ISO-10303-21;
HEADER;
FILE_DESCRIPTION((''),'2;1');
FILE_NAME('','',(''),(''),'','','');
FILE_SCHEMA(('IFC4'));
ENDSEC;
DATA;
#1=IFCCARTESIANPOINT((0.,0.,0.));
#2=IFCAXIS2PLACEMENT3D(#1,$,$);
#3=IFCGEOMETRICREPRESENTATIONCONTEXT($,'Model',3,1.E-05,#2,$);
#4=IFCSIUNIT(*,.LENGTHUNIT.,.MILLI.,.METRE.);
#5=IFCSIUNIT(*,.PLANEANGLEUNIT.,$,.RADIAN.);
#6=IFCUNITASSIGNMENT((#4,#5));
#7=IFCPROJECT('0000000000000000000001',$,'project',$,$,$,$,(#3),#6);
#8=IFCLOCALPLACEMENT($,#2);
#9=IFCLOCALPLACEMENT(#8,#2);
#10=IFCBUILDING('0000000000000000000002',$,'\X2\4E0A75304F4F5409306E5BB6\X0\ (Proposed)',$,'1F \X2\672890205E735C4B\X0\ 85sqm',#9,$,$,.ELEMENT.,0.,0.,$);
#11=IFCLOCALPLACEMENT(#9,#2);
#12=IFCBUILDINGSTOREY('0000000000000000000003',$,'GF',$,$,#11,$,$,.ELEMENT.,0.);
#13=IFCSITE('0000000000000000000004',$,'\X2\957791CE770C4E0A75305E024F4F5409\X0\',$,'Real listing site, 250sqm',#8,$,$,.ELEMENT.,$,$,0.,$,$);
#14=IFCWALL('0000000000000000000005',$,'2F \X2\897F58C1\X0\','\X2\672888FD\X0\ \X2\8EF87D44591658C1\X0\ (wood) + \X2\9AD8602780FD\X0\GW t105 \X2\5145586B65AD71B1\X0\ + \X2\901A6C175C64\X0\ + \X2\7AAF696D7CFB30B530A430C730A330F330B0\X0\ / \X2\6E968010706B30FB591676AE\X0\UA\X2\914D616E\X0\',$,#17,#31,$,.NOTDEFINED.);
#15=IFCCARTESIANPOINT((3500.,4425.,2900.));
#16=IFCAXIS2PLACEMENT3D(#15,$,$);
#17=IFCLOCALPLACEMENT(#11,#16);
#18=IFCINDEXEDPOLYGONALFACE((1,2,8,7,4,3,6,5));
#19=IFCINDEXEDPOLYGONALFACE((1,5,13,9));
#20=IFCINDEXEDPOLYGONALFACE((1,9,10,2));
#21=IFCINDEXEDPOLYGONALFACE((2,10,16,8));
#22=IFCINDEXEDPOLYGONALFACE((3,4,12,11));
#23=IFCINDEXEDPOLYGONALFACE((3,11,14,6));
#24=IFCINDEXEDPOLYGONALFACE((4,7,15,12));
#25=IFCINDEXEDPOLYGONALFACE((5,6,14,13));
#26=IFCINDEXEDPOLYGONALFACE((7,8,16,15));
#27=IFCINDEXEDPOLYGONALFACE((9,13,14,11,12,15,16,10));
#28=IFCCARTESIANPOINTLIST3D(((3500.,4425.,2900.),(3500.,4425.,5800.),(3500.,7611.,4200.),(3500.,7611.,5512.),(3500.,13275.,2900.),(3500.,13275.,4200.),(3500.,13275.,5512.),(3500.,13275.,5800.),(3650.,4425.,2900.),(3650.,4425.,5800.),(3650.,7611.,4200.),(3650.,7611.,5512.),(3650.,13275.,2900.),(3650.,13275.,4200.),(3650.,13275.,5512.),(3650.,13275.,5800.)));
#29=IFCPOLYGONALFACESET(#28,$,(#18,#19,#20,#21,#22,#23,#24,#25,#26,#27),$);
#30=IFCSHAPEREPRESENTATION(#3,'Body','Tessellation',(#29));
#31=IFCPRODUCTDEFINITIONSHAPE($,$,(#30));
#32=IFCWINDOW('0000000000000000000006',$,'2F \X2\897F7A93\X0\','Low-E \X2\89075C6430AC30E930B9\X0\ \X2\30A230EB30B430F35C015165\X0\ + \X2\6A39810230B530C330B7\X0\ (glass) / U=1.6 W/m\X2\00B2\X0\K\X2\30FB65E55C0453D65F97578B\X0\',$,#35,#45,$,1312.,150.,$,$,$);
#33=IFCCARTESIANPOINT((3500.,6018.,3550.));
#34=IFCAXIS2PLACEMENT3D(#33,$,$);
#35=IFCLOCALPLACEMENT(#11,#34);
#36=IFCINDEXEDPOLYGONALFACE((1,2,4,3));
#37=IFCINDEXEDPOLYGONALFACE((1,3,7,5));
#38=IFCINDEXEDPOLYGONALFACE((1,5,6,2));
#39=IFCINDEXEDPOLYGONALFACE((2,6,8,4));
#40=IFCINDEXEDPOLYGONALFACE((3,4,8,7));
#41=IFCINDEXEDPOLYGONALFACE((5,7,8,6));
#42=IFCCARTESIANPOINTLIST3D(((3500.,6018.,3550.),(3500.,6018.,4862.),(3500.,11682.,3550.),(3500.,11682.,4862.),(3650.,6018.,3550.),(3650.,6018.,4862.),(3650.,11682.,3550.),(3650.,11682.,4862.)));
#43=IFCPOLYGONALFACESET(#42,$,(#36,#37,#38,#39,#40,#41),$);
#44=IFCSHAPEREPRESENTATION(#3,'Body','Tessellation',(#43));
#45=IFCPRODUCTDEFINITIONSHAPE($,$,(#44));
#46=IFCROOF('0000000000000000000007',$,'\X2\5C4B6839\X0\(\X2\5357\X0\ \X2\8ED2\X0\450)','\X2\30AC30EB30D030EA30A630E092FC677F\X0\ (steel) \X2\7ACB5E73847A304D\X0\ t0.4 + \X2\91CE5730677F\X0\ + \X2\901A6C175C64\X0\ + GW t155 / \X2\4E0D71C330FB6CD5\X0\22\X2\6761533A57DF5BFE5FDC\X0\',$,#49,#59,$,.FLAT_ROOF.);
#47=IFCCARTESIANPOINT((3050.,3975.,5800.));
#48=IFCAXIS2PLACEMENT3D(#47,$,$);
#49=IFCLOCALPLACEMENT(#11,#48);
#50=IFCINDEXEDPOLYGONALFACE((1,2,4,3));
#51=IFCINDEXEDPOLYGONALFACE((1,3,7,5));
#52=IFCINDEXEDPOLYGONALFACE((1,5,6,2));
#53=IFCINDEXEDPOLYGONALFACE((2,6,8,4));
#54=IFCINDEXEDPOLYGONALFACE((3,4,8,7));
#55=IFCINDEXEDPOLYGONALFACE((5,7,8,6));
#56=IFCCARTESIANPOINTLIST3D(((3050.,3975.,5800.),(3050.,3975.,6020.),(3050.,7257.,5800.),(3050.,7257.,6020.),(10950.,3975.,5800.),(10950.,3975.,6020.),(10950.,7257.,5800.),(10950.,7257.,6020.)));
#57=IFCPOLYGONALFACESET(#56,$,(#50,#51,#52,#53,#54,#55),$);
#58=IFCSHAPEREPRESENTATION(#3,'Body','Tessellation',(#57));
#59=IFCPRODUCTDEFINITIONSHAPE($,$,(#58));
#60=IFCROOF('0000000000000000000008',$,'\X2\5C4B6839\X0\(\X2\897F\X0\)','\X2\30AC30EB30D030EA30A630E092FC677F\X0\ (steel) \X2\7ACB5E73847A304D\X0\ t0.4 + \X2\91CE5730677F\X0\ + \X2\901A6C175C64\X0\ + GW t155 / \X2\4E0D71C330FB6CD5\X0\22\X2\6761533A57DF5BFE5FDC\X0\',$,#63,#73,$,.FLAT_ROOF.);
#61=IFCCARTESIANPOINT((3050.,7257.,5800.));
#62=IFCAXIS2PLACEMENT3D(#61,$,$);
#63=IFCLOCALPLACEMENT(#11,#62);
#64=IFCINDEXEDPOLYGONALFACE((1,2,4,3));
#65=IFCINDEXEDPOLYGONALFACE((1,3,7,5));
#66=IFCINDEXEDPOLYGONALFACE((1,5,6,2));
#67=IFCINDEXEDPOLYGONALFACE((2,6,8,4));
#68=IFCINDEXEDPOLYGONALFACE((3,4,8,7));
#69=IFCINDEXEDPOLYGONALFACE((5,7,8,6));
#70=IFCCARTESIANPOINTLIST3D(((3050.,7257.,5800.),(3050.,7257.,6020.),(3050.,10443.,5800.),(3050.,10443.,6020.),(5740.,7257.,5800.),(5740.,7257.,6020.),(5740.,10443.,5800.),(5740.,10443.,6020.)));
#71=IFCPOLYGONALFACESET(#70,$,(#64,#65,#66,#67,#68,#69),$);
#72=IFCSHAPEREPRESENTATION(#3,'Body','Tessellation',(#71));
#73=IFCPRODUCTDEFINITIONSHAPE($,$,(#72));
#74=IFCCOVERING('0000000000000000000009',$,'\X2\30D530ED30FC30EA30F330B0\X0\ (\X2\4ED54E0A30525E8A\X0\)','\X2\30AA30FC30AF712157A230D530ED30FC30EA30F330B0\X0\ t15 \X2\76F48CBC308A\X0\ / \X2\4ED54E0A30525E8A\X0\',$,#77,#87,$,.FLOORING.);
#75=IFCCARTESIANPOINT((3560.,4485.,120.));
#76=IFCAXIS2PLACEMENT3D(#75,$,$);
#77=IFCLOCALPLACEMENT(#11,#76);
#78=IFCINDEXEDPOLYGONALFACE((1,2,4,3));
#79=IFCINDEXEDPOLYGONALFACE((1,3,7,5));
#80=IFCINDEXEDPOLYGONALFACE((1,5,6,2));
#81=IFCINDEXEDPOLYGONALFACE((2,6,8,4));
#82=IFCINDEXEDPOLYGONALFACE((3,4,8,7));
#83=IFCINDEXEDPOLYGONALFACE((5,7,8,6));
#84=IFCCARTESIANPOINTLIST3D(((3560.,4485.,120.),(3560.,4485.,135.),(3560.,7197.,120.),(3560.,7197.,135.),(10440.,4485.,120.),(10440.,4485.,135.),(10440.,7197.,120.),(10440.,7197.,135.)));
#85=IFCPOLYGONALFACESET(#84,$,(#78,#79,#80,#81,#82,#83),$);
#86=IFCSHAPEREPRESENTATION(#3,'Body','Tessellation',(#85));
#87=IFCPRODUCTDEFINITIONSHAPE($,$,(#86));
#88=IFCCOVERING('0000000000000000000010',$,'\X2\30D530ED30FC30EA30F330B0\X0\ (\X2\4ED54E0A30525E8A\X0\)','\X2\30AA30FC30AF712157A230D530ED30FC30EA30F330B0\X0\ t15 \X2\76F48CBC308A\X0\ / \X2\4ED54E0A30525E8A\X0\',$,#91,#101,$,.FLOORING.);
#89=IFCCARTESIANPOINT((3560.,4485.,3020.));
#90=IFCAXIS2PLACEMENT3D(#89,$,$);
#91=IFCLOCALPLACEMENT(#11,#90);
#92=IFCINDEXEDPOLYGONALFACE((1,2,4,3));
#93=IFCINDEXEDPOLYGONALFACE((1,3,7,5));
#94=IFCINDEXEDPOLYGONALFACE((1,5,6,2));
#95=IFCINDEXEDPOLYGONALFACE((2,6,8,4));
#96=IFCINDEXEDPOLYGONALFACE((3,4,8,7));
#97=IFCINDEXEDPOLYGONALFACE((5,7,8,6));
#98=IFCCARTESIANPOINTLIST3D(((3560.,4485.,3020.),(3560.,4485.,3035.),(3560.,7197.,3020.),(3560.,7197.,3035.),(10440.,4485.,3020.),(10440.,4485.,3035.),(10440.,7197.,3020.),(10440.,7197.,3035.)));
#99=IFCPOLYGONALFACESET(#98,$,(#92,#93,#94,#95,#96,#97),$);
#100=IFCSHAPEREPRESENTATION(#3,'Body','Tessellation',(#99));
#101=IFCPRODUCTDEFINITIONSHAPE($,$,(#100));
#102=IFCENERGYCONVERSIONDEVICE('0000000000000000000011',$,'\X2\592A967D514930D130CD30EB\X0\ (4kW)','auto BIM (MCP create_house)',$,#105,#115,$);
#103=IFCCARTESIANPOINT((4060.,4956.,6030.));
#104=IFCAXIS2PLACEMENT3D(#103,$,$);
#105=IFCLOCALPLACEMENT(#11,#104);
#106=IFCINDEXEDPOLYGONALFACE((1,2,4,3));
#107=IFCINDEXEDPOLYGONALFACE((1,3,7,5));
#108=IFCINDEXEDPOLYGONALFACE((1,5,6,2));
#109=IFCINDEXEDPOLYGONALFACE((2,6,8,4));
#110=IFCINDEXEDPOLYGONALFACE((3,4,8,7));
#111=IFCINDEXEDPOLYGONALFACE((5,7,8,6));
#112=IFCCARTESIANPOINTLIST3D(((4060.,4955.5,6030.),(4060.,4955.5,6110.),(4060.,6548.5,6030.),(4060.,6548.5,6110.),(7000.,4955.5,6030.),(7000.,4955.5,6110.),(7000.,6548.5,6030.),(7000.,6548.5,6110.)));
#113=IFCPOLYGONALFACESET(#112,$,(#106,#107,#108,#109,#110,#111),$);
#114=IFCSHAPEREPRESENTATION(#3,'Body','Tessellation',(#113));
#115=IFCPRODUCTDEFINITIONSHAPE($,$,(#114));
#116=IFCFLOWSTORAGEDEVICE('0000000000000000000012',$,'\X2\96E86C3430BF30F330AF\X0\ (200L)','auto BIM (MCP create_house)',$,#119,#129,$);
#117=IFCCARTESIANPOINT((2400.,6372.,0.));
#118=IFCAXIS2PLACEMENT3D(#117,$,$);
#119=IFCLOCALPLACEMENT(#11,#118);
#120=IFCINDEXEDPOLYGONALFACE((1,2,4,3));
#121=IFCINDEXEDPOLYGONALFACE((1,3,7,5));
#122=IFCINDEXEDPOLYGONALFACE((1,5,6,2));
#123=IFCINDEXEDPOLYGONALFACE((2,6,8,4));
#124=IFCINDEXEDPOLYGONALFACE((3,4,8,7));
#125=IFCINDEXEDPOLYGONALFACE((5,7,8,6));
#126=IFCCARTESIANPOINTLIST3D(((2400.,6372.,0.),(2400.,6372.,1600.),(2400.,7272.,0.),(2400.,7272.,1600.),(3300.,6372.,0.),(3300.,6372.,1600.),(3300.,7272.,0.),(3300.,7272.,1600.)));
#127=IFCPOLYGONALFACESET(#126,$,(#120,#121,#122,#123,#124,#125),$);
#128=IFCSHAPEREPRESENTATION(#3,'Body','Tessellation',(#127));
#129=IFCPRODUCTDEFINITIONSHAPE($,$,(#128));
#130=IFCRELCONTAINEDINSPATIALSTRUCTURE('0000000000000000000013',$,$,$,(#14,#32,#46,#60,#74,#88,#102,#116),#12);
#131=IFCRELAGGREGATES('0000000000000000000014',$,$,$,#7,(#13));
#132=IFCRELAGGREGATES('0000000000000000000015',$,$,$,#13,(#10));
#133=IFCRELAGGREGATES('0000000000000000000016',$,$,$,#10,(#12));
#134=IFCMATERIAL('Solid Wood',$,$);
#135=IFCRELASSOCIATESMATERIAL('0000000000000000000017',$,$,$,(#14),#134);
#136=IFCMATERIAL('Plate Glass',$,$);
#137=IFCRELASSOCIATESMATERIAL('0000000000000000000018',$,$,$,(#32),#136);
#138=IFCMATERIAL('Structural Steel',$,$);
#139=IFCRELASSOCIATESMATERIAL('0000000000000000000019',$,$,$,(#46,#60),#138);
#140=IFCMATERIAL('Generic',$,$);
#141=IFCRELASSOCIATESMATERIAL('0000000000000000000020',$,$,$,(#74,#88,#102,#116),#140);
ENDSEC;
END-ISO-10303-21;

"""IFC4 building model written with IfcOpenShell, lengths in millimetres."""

from ifc_helpers import new_model, si_unit, frame, frame_2d, origin, place, context, project, spatial, rectangle, extrude, material, element, fill, save


model = new_model("IFC4")

# Units and contexts
model_context = context("Model", 3, precision=1e-05, world=origin())
ifc_project = project(units=[si_unit("LENGTHUNIT", "METRE", prefix="MILLI"), si_unit("PLANEANGLEUNIT", "RADIAN")], contexts=[model_context])

# Site, building, storey
site_placement = place(None, origin())
site = spatial("IfcSite", under=ifc_project, at=site_placement, Name="長野県上田市住吉", ObjectType="Real listing site, 250sqm", CompositionType="ELEMENT", RefElevation=0.0)
building_placement = place(site_placement, origin())
building = spatial("IfcBuilding", under=site, at=building_placement, Name="上田住吉の家 (Proposed)", ObjectType="1F 木造平屋 85sqm", CompositionType="ELEMENT", ElevationOfRefHeight=0.0, ElevationOfTerrain=0.0)
storey_placement = place(building_placement, origin())
storey = spatial("IfcBuildingStorey", under=building, at=storey_placement, Name="GF", CompositionType="ELEMENT", Elevation=0.0)

# Shared definitions
ifc_material_1 = material(Name="Solid Wood")
ifc_material_2 = material(Name="Generic")

# Shared definitions
ifc_material_3 = material(Name="Plate Glass")

# Wall, opening, window
wall_1_placement = place(storey_placement, frame((3500.0, 4425.0, 2900.0)))
wall_1 = element("IfcWall", 1, at=wall_1_placement, inside=storey, material=ifc_material_1, Name="2F 西壁", Description="木製 軸組外壁 (wood) + 高性能GW t105 充填断熱 + 通気層 + 窯業系サイディング / 準耐火・外皮UA配慮", PredefinedType="NOTDEFINED", context=model_context, shape_type="SweptSolid", body=[
    extrude(rectangle(XDim=150.0, YDim=8850.0, at=frame_2d((75.0, 4425.0))), frame((3500.0, 4425.0, 2900.0)), (0.0, 0.0, 1.0), 2900.0),
])
opening_1_placement = place(storey_placement, frame((3500.0, 6018.0, 3550.0)))
opening_1 = element("IfcOpeningElement", 2, at=opening_1_placement, cuts=wall_1, PredefinedType="NOTDEFINED", context=model_context, shape_type="SweptSolid", body=[
    extrude(rectangle(XDim=150.0, YDim=5664.0, at=frame_2d((75.0, 2832.0))), frame((3500.0, 6018.0, 3550.0)), (0.0, 0.0, 1.0), 1312.0),
])
window_1_placement = place(storey_placement, frame((3500.0, 6018.0, 3550.0)))
window_1 = element("IfcWindow", 3, at=window_1_placement, inside=storey, material=ifc_material_3, Name="2F 西窓", Description="Low-E 複層ガラス アルゴン封入 + 樹脂サッシ (glass) / U=1.6 W/m²K・日射取得型", OverallHeight=1312.0, OverallWidth=150.0, context=model_context, shape_type="SweptSolid", body=[
    extrude(rectangle(XDim=150.0, YDim=5664.0, at=frame_2d((75.0, 2832.0))), frame((3500.0, 6018.0, 3550.0)), (0.0, 0.0, 1.0), 1312.0),
])
fill(opening_1, window_1)

# Roofs
ifc_material_4 = material(Name="Structural Steel")
roof_1_placement = place(storey_placement, frame((3050.0, 3975.0, 5800.0)))
element("IfcRoof", 4, at=roof_1_placement, inside=storey, material=ifc_material_4, Name="屋根(南 軒450)", Description="ガルバリウム鋼板 (steel) 立平葺き t0.4 + 野地板 + 通気層 + GW t155 / 不燃・法22条区域対応", PredefinedType="FLAT_ROOF", context=model_context, shape_type="SweptSolid", body=[
    extrude(rectangle(XDim=7900.0, YDim=3282.0, at=frame_2d((3950.0, 1641.0))), frame((3050.0, 3975.0, 5800.0)), (0.0, 0.0, 1.0), 220.0),
])
roof_2_placement = place(storey_placement, frame((3050.0, 7257.0, 5800.0)))
element("IfcRoof", 5, at=roof_2_placement, inside=storey, material=ifc_material_4, Name="屋根(西)", Description="ガルバリウム鋼板 (steel) 立平葺き t0.4 + 野地板 + 通気層 + GW t155 / 不燃・法22条区域対応", PredefinedType="FLAT_ROOF", context=model_context, shape_type="SweptSolid", body=[
    extrude(rectangle(XDim=2690.0, YDim=3186.0, at=frame_2d((1345.0, 1593.0))), frame((3050.0, 7257.0, 5800.0)), (0.0, 0.0, 1.0), 220.0),
])

# Coverings
covering_1_placement = place(storey_placement, frame((3560.0, 4485.0, 120.0)))
element("IfcCovering", 6, at=covering_1_placement, inside=storey, material=ifc_material_2, Name="フローリング (仕上げ床)", Description="オーク無垢フローリング t15 直貼り / 仕上げ床", PredefinedType="FLOORING", context=model_context, shape_type="SweptSolid", body=[
    extrude(rectangle(XDim=6880.0, YDim=2712.0, at=frame_2d((3440.0, 1356.0))), frame((3560.0, 4485.0, 120.0)), (0.0, 0.0, 1.0), 15.0),
])
covering_2_placement = place(storey_placement, frame((3560.0, 4485.0, 3020.0)))
element("IfcCovering", 7, at=covering_2_placement, inside=storey, material=ifc_material_2, Name="フローリング (仕上げ床)", Description="オーク無垢フローリング t15 直貼り / 仕上げ床", PredefinedType="FLOORING", context=model_context, shape_type="SweptSolid", body=[
    extrude(rectangle(XDim=6880.0, YDim=2712.0, at=frame_2d((3440.0, 1356.0))), frame((3560.0, 4485.0, 3020.0)), (0.0, 0.0, 1.0), 15.0),
])

# Energy conversion device
energy_conversion_device_placement = place(storey_placement, frame((4060.0, 4956.0, 6030.0)))
element("IfcEnergyConversionDevice", 8, at=energy_conversion_device_placement, inside=storey, material=ifc_material_2, Name="太陽光パネル (4kW)", Description="auto BIM (MCP create_house)", context=model_context, shape_type="SweptSolid", body=[
    extrude(rectangle(XDim=2940.0, YDim=1593.0, at=frame_2d((1470.0, 796.0))), frame((4060.0, 4956.0, 6030.0)), (0.0, 0.0, 1.0), 80.0),
])

# Flow storage device
flow_storage_device_placement = place(storey_placement, frame((2400.0, 6372.0, 0.0)))
element("IfcFlowStorageDevice", 9, at=flow_storage_device_placement, inside=storey, material=ifc_material_2, Name="雨水タンク (200L)", Description="auto BIM (MCP create_house)", context=model_context, shape_type="SweptSolid", body=[
    extrude(rectangle(XDim=900.0, YDim=900.0, at=frame_2d((450.0, 450.0))), frame((2400.0, 6372.0, 0.0)), (0.0, 0.0, 1.0), 1600.0),
])

save(model, "model.ifc")
